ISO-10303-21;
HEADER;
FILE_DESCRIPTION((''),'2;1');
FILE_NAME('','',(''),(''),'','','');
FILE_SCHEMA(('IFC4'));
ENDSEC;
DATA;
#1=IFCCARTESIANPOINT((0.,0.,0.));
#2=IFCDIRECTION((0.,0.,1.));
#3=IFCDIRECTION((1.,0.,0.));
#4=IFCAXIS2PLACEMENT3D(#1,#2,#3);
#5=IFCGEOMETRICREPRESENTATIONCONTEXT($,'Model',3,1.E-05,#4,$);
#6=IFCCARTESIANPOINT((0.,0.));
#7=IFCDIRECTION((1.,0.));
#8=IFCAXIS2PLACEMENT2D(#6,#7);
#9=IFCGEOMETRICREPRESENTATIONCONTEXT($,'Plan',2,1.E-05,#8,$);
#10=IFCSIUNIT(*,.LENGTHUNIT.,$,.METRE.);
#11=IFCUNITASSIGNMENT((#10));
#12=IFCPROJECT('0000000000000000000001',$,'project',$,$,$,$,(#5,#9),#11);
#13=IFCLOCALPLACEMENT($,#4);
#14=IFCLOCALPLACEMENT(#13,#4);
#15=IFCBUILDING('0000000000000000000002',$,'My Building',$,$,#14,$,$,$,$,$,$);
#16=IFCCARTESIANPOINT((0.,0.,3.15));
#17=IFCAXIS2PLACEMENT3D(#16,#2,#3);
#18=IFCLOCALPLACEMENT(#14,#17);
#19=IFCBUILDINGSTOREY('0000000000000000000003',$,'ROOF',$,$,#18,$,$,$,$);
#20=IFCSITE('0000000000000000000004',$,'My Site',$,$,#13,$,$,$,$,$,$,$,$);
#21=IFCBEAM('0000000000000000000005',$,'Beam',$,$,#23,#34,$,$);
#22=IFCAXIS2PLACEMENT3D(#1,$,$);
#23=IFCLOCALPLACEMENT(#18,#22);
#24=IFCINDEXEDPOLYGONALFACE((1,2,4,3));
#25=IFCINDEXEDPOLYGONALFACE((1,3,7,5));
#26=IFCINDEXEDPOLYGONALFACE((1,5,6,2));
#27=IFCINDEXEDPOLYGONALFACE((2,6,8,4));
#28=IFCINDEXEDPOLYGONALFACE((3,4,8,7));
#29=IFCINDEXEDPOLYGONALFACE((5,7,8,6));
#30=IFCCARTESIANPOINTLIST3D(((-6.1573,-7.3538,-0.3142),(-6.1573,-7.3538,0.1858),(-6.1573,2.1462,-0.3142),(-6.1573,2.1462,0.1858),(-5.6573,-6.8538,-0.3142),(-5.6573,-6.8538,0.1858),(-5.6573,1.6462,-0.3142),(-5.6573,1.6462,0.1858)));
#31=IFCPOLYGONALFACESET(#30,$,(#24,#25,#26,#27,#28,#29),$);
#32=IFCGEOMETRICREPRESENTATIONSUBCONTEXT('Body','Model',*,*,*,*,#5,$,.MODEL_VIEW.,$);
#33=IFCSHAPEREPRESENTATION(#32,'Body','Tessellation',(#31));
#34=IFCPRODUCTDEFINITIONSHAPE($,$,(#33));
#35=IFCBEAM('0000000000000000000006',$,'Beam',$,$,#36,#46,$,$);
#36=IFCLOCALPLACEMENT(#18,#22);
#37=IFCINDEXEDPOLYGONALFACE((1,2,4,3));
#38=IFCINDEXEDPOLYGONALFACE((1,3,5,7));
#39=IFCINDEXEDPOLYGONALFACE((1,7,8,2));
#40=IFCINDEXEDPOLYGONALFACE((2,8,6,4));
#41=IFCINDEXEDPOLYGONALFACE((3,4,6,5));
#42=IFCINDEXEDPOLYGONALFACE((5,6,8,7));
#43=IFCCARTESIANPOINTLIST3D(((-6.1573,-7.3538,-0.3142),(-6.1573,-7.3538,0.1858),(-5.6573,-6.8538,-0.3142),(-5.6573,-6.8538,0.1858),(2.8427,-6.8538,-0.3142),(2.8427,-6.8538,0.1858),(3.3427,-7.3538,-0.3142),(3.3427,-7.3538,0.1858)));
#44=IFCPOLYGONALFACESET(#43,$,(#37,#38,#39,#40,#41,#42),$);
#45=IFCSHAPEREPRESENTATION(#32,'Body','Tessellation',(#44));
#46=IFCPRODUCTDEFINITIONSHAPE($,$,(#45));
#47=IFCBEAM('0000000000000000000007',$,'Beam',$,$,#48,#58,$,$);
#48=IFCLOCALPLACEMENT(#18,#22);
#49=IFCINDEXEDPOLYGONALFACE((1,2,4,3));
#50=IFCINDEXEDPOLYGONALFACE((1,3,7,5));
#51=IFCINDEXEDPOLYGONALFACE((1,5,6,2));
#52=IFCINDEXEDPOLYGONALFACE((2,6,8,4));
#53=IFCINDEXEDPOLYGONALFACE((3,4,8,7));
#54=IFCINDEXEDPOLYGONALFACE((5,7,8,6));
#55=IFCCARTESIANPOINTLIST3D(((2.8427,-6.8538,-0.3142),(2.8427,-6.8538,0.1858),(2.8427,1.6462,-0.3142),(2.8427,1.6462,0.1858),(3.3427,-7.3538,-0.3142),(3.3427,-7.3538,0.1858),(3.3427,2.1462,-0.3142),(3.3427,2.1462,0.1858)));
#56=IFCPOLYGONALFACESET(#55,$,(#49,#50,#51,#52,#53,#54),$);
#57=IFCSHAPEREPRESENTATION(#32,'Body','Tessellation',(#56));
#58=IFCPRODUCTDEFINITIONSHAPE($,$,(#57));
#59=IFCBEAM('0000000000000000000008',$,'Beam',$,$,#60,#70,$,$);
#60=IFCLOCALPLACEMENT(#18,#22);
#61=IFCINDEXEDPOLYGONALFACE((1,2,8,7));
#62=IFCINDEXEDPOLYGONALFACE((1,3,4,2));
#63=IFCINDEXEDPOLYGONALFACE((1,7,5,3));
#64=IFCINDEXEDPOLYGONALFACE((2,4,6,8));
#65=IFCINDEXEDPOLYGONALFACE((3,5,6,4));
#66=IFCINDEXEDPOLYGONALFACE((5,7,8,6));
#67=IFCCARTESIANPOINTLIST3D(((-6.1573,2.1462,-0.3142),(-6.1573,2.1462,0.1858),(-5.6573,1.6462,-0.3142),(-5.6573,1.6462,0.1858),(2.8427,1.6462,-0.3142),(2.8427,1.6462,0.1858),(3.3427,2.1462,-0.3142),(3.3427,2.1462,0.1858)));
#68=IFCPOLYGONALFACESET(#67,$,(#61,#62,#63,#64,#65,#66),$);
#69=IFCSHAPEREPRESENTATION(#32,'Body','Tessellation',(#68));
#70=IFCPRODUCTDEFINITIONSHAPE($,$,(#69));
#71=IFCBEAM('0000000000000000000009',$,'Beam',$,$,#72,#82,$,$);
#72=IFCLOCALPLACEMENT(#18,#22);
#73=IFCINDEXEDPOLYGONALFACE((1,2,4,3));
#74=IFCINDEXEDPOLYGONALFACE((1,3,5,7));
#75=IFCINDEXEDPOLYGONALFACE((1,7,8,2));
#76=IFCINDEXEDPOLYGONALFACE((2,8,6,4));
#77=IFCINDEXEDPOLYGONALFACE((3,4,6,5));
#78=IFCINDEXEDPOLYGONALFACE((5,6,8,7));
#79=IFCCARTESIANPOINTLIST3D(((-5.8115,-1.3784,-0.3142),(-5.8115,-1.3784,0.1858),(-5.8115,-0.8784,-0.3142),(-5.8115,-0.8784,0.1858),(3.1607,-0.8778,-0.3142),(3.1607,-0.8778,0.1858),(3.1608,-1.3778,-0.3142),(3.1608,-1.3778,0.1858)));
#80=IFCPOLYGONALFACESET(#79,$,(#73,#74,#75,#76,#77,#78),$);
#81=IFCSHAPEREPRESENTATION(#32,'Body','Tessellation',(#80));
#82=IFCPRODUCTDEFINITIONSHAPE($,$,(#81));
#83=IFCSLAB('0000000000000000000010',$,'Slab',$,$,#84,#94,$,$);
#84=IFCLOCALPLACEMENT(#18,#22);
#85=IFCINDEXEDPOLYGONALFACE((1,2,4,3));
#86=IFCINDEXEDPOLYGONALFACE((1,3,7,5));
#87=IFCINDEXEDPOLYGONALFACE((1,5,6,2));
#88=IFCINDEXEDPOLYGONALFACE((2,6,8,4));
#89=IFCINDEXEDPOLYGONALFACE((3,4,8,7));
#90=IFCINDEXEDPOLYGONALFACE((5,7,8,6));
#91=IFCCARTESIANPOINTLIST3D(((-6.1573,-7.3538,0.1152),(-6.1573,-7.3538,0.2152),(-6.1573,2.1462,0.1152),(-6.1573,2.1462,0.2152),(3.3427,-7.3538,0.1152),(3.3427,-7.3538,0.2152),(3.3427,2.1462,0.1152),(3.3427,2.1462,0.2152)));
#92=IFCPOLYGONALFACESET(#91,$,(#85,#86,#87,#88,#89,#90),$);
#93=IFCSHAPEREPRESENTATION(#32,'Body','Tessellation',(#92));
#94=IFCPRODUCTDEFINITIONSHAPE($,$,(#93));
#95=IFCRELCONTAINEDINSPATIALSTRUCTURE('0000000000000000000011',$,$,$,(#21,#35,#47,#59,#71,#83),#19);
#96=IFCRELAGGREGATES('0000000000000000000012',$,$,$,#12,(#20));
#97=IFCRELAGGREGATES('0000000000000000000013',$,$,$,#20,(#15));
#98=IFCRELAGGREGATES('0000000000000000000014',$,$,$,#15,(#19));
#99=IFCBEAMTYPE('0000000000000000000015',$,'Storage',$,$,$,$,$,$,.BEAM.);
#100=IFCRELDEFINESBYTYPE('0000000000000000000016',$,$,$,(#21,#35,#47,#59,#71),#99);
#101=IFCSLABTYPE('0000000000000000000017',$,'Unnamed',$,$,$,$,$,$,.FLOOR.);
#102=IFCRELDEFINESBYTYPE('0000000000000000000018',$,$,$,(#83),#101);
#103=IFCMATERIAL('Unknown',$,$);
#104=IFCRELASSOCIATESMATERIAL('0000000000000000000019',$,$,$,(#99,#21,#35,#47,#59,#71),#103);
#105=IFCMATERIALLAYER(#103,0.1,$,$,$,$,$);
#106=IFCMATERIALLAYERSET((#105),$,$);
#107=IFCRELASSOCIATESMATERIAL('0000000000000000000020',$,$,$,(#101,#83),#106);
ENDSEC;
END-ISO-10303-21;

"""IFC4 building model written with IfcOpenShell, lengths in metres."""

from ifc_helpers import new_model, si_unit, frame, origin_with_axes, origin_2d_with_axis, place, context, subcontext, project, spatial, indexed_curve, rectangle, outline, extrude, clip, halfspace, material, layer, layer_set, layer_usage, material_profile, profile_set, profile_usage, type_object, element, save


model = new_model("IFC4")

# Units and contexts
model_context = context("Model", 3, precision=1e-05, world=origin_with_axes())
plan_context = context("Plan", 2, precision=1e-05, world=origin_2d_with_axis())
body_context = subcontext(model_context, "Body", "Model", "MODEL_VIEW")
ifc_project = project(units=[si_unit("LENGTHUNIT", "METRE")], contexts=[model_context, plan_context])

# Site, building, storey
site_placement = place(None, origin_with_axes())
site = spatial("IfcSite", under=ifc_project, at=site_placement, Name="My Site")
building_placement = place(site_placement, origin_with_axes())
building = spatial("IfcBuilding", under=site, at=building_placement, Name="My Building")
storey_placement = place(building_placement, frame((0.0, 0.0, 3.15), z_axis=(0.0, 0.0, 1.0), x_axis=(1.0, 0.0, 0.0)))
storey = spatial("IfcBuildingStorey", under=building, at=storey_placement, Name="ROOF")

# Beams
ifc_material = material(Name="Unknown")
ifc_material_profile = material_profile(ifc_material, rectangle(XDim=0.5, YDim=0.5))
ifc_profile_set = profile_set([ifc_material_profile])
ifc_profile_usage_1 = profile_usage(ifc_profile_set, cardinal=5)
beam_type = type_object("IfcBeamType", Name="Storage", PredefinedType="BEAM", material=ifc_profile_set)
beam_1_placement = place(storey_placement, frame((-5.9073, 2.1462, -0.0642), z_axis=(0.0, -1.0, 0.0), x_axis=(1.0, 0.0, 0.0)))
element("IfcBeam", 1, at=beam_1_placement, inside=storey, type_object=beam_type, material=ifc_profile_usage_1, Name="Beam", context=body_context, shape_type="Clipping", body=[
    clip(clip(extrude(rectangle(XDim=0.5, YDim=0.5), origin_with_axes(), (0.0, 0.0, 1.0), 9.5), halfspace(frame((-0.25, -2.8358, 9.5), z_axis=(0.707106, 0.0, 0.707107), x_axis=(0.0, -1.0, 0.0)), False)), halfspace(frame((-0.25, -2.8358, 0.0), z_axis=(0.707106, 0.0, -0.707107), x_axis=(0.0, -1.0, 0.0)), False)),
])
ifc_profile_usage_2 = profile_usage(ifc_profile_set, cardinal=5)
beam_2_placement = place(storey_placement, frame((-6.1573, -7.1038, -0.0642), z_axis=(1.0, -0.000001, 0.000001), x_axis=(0.000001, 1.0, 0.0)))
element("IfcBeam", 2, at=beam_2_placement, inside=storey, type_object=beam_type, material=ifc_profile_usage_2, Name="Beam", context=body_context, shape_type="Clipping", body=[
    clip(clip(extrude(rectangle(XDim=0.5, YDim=0.5), origin_with_axes(), (0.0, 0.0, 1.0), 9.5), halfspace(frame((-0.25, -2.8358, 9.5), z_axis=(0.707108, 0.0, 0.707106), x_axis=(-0.000001, -1.0, 0.0)), False)), halfspace(frame((-0.25, -2.8358, 0.0), z_axis=(0.707107, 0.0, -0.707107), x_axis=(0.0, -1.0, 0.0)), False)),
])
ifc_profile_usage_3 = profile_usage(ifc_profile_set, cardinal=5)
beam_3_placement = place(storey_placement, frame((3.0927, -7.3538, -0.0642), z_axis=(0.0, 1.0, 0.0), x_axis=(-1.0, 0.0, 0.0)))
element("IfcBeam", 3, at=beam_3_placement, inside=storey, type_object=beam_type, material=ifc_profile_usage_3, Name="Beam", context=body_context, shape_type="Clipping", body=[
    clip(clip(extrude(rectangle(XDim=0.5, YDim=0.5), origin_with_axes(), (0.0, 0.0, 1.0), 9.5), halfspace(frame((-0.25, -2.8358, 9.5), z_axis=(0.707107, 0.0, 0.707107), x_axis=(-0.000001, -1.0, 0.0)), False)), halfspace(frame((-0.25, -2.8358, 0.0), z_axis=(0.707107, 0.0, -0.707107), x_axis=(0.000001, -1.0, 0.0)), False)),
])
ifc_profile_usage_4 = profile_usage(ifc_profile_set, cardinal=5)
beam_4_placement = place(storey_placement, frame((3.3427, 1.8962, -0.0642), z_axis=(-1.0, -0.000001, 0.000001), x_axis=(0.000001, -1.0, 0.0)))
element("IfcBeam", 4, at=beam_4_placement, inside=storey, type_object=beam_type, material=ifc_profile_usage_4, Name="Beam", context=body_context, shape_type="Clipping", body=[
    clip(clip(extrude(rectangle(XDim=0.5, YDim=0.5), origin_with_axes(), (0.0, 0.0, 1.0), 9.5), halfspace(frame((-0.25, -2.8358, 9.5), z_axis=(0.707107, 0.0, 0.707107), x_axis=(0.0, -1.0, 0.0)), False)), halfspace(frame((-0.25, -2.8358, 0.0), z_axis=(0.707107, 0.0, -0.707106), x_axis=(0.000001, -1.0, 0.0)), False)),
])
ifc_profile_usage_5 = profile_usage(ifc_profile_set, cardinal=5)
beam_5_placement = place(storey_placement, frame((3.1608, -1.1278, -0.0642), z_axis=(-1.0, -0.00007, 0.0), x_axis=(0.00007, -1.0, 0.0)))
element("IfcBeam", 5, at=beam_5_placement, inside=storey, type_object=beam_type, material=ifc_profile_usage_5, Name="Beam", context=body_context, shape_type="SweptSolid", body=[
    extrude(rectangle(XDim=0.5, YDim=0.5), origin_with_axes(), (0.0, 0.0, 1.0), 8.9723),
])

# Slab
ifc_layer = layer(ifc_material, 0.1)
ifc_layer_set = layer_set([ifc_layer])
ifc_layer_usage = layer_usage(ifc_layer_set, "AXIS3", "POSITIVE", -0.1)
slab_type = type_object("IfcSlabType", Name="Unnamed", PredefinedType="FLOOR", material=ifc_layer_set)
slab_placement = place(storey_placement, frame((-6.1573, 2.1462, 0.2152), z_axis=(0.0, 0.0, 1.0), x_axis=(1.0, 0.0, 0.0)))
element("IfcSlab", 6, at=slab_placement, inside=storey, type_object=slab_type, material=ifc_layer_usage, Name="Slab", context=body_context, shape_type="SweptSolid", body=[
    extrude(outline(indexed_curve([(0.0, 0.0), (0.0, -9.5), (9.5, -9.5), (9.5, 0.0), (0.0, 0.0)])), frame((0.0, 0.0, -0.1), z_axis=(0.0, 0.0, 1.0), x_axis=(1.0, 0.0, 0.0)), (0.0, 0.0, 1.0), 0.1),
])

save(model, "model.ifc")
